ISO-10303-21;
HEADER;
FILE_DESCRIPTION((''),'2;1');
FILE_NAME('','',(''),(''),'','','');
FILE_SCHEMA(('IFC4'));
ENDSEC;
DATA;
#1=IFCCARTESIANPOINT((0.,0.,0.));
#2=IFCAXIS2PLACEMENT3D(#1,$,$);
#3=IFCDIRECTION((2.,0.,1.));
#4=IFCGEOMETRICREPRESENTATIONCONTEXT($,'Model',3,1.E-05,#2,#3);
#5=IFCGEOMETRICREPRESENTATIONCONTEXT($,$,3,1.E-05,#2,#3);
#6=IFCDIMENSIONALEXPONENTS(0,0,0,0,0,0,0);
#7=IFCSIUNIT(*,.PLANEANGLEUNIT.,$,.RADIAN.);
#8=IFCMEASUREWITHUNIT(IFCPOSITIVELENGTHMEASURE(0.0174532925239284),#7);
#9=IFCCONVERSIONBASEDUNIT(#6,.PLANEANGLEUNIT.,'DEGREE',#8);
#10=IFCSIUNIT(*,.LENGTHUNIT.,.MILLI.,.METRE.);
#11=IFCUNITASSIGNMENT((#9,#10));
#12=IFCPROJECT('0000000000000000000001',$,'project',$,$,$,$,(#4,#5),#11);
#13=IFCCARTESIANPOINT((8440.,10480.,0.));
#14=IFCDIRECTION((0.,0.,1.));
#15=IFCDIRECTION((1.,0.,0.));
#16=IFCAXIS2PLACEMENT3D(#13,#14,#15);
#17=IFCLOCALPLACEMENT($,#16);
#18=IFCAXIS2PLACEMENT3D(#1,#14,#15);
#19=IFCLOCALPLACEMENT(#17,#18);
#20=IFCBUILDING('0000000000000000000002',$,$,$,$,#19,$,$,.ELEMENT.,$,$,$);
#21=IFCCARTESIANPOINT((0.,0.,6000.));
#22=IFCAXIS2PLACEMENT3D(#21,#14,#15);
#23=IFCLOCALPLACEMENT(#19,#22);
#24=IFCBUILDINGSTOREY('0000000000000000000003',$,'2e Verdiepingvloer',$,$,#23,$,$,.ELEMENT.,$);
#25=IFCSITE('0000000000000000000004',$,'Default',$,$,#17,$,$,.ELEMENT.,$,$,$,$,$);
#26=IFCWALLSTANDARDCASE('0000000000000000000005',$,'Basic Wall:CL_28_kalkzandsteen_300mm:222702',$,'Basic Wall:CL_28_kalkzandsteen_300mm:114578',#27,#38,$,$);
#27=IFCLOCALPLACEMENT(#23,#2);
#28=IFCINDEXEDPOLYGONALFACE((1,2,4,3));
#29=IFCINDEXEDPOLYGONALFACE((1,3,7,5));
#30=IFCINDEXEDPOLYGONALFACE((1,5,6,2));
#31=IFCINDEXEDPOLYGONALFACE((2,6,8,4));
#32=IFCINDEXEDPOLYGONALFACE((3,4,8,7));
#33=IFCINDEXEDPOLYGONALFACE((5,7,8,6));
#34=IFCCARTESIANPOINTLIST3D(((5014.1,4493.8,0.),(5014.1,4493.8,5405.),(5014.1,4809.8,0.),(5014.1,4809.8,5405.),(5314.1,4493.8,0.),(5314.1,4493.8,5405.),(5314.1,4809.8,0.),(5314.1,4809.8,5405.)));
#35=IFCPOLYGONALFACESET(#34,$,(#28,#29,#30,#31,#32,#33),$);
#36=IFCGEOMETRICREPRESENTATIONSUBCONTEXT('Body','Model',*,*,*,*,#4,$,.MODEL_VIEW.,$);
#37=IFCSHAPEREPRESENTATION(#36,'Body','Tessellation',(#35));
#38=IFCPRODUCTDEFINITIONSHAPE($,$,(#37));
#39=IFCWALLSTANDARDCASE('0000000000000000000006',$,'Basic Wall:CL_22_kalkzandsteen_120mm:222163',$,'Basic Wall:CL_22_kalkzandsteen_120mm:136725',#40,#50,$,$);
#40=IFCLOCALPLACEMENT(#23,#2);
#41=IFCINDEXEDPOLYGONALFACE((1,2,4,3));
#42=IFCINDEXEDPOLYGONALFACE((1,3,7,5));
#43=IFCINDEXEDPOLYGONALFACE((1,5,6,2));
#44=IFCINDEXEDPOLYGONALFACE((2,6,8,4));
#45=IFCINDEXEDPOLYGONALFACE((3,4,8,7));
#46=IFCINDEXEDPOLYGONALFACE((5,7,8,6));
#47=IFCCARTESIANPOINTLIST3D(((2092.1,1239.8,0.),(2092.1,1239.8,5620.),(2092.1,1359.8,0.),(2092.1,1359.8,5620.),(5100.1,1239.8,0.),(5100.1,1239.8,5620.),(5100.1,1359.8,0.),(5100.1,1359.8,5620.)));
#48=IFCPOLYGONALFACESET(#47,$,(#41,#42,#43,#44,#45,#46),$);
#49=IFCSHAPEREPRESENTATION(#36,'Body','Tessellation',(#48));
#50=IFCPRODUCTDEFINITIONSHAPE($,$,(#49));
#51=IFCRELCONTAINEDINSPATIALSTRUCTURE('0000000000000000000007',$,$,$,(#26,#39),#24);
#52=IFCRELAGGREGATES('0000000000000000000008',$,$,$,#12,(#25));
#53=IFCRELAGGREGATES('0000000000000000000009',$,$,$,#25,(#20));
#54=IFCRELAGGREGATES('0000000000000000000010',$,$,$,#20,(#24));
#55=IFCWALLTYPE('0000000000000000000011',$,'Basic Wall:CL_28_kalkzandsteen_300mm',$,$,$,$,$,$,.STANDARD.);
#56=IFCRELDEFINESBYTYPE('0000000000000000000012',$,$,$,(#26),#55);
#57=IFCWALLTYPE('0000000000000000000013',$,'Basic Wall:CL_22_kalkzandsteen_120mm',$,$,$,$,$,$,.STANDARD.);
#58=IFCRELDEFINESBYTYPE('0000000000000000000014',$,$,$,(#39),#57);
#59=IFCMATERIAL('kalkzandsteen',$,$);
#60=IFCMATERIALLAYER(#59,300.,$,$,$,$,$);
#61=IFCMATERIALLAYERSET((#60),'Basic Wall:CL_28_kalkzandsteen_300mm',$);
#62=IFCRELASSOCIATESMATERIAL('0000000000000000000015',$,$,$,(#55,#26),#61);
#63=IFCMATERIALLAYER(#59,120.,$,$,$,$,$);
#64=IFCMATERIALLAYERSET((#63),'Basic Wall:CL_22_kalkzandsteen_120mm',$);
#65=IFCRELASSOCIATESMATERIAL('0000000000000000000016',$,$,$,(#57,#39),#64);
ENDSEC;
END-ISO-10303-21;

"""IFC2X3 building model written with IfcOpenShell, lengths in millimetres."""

from ifc_helpers import new_model, entity, si_unit, converted_unit, direction, frame, frame_2d, origin, origin_with_axes, place, context, subcontext, project, spatial, polyline, rectangle, extrude, clip, bounded_halfspace, material, layer, layer_set, layer_usage, type_object, element, save


model = new_model("IFC2X3")

# Units and contexts
model_context = context("Model", 3, precision=1e-05, world=origin(), true_north=direction((2.0, 0.0, 1.0)))
context_of_model = context(None, 3, precision=1e-05, world=origin(), true_north=direction((2.0, 0.0, 1.0)))
body_context = subcontext(model_context, "Body", "Model", "MODEL_VIEW")
ifc_project = project(units=[converted_unit("PLANEANGLEUNIT", "DEGREE", entity("IfcPositiveLengthMeasure", 0.0174532925239284), si_unit("PLANEANGLEUNIT", "RADIAN"), dimensions=[0, 0, 0, 0, 0, 0, 0]), si_unit("LENGTHUNIT", "METRE", prefix="MILLI")], contexts=[model_context, context_of_model])

# Site, building, storey
site_placement = place(None, frame((8440.0, 10480.0, 0.0), z_axis=(0.0, 0.0, 1.0), x_axis=(1.0, 0.0, 0.0)))
site = spatial("IfcSite", under=ifc_project, at=site_placement, Name="Default", CompositionType="ELEMENT")
building_placement = place(site_placement, origin_with_axes())
building = spatial("IfcBuilding", under=site, at=building_placement, CompositionType="ELEMENT")
storey_placement = place(building_placement, frame((0.0, 0.0, 6000.0), z_axis=(0.0, 0.0, 1.0), x_axis=(1.0, 0.0, 0.0)))
storey = spatial("IfcBuildingStorey", under=building, at=storey_placement, Name="2e Verdiepingvloer", CompositionType="ELEMENT")

# Walls
ifc_material_1 = material(Name="kalkzandsteen")
ifc_layer_1 = layer(ifc_material_1, 300.0)
ifc_layer_set_1 = layer_set([ifc_layer_1], Name="Basic Wall:CL_28_kalkzandsteen_300mm")
ifc_layer_usage_1 = layer_usage(ifc_layer_set_1, "AXIS2", "NEGATIVE", 150.0)
wall_type_1 = type_object("IfcWallType", Name="Basic Wall:CL_28_kalkzandsteen_300mm", PredefinedType="STANDARD", material=ifc_layer_set_1)
wall_1_placement = place(storey_placement, frame((5164.1, 4493.8, 0.0), z_axis=(0.0, 0.0, 1.0), x_axis=(0.0, 1.0, 0.0)))
element("IfcWallStandardCase", 1, at=wall_1_placement, inside=storey, type_object=wall_type_1, material=ifc_layer_usage_1, Name="Basic Wall:CL_28_kalkzandsteen_300mm:222702", ObjectType="Basic Wall:CL_28_kalkzandsteen_300mm:114578", context=body_context, shape_type="Clipping", body=[
    clip(extrude(rectangle(XDim=316.0, YDim=300.0, at=frame_2d((158.0, 0.0), x_axis=(-1.0, 0.0))), origin(), (0.0, 0.0, 1.0), 5860.0), bounded_halfspace(frame((0.0, -150.0, 5405.0), z_axis=(0.0, 0.0, 1.0), x_axis=(0.0, -1.0, 0.0)), False, frame((0.0, -150.0, 5405.0)), polyline([(0.0, 0.0), (316.0, 0.0), (316.0, 300.0), (0.0, 300.0), (0.0, 0.0)]))),
])
ifc_layer_2 = layer(ifc_material_1, 120.0)
ifc_layer_set_2 = layer_set([ifc_layer_2], Name="Basic Wall:CL_22_kalkzandsteen_120mm")
ifc_layer_usage_2 = layer_usage(ifc_layer_set_2, "AXIS2", "NEGATIVE", 60.0)
wall_type_2 = type_object("IfcWallType", Name="Basic Wall:CL_22_kalkzandsteen_120mm", PredefinedType="STANDARD", material=ifc_layer_set_2)
wall_2_placement = place(storey_placement, frame((2092.1, 1299.8, 0.0), z_axis=(0.0, 0.0, 1.0), x_axis=(1.0, 0.0, 0.0)))
element("IfcWallStandardCase", 2, at=wall_2_placement, inside=storey, type_object=wall_type_2, material=ifc_layer_usage_2, Name="Basic Wall:CL_22_kalkzandsteen_120mm:222163", ObjectType="Basic Wall:CL_22_kalkzandsteen_120mm:136725", context=body_context, shape_type="Clipping", body=[
    clip(extrude(rectangle(XDim=3008.0, YDim=120.0, at=frame_2d((1504.0, 0.0), x_axis=(-1.0, 0.0))), origin(), (0.0, 0.0, 1.0), 5620.0), bounded_halfspace(frame((0.0, -60.0, 5620.0), z_axis=(0.0, 0.0, -1.0), x_axis=(0.0, -1.0, 0.0)), True, frame((0.0, -60.0, 5620.0)), polyline([(0.0, 0.0), (2922.0, 0.0), (3008.0, 0.0), (3008.0, 120.0), (14.0, 120.0), (0.0, 120.0), (0.0, 0.0)]))),
])

save(model, "model.ifc")
